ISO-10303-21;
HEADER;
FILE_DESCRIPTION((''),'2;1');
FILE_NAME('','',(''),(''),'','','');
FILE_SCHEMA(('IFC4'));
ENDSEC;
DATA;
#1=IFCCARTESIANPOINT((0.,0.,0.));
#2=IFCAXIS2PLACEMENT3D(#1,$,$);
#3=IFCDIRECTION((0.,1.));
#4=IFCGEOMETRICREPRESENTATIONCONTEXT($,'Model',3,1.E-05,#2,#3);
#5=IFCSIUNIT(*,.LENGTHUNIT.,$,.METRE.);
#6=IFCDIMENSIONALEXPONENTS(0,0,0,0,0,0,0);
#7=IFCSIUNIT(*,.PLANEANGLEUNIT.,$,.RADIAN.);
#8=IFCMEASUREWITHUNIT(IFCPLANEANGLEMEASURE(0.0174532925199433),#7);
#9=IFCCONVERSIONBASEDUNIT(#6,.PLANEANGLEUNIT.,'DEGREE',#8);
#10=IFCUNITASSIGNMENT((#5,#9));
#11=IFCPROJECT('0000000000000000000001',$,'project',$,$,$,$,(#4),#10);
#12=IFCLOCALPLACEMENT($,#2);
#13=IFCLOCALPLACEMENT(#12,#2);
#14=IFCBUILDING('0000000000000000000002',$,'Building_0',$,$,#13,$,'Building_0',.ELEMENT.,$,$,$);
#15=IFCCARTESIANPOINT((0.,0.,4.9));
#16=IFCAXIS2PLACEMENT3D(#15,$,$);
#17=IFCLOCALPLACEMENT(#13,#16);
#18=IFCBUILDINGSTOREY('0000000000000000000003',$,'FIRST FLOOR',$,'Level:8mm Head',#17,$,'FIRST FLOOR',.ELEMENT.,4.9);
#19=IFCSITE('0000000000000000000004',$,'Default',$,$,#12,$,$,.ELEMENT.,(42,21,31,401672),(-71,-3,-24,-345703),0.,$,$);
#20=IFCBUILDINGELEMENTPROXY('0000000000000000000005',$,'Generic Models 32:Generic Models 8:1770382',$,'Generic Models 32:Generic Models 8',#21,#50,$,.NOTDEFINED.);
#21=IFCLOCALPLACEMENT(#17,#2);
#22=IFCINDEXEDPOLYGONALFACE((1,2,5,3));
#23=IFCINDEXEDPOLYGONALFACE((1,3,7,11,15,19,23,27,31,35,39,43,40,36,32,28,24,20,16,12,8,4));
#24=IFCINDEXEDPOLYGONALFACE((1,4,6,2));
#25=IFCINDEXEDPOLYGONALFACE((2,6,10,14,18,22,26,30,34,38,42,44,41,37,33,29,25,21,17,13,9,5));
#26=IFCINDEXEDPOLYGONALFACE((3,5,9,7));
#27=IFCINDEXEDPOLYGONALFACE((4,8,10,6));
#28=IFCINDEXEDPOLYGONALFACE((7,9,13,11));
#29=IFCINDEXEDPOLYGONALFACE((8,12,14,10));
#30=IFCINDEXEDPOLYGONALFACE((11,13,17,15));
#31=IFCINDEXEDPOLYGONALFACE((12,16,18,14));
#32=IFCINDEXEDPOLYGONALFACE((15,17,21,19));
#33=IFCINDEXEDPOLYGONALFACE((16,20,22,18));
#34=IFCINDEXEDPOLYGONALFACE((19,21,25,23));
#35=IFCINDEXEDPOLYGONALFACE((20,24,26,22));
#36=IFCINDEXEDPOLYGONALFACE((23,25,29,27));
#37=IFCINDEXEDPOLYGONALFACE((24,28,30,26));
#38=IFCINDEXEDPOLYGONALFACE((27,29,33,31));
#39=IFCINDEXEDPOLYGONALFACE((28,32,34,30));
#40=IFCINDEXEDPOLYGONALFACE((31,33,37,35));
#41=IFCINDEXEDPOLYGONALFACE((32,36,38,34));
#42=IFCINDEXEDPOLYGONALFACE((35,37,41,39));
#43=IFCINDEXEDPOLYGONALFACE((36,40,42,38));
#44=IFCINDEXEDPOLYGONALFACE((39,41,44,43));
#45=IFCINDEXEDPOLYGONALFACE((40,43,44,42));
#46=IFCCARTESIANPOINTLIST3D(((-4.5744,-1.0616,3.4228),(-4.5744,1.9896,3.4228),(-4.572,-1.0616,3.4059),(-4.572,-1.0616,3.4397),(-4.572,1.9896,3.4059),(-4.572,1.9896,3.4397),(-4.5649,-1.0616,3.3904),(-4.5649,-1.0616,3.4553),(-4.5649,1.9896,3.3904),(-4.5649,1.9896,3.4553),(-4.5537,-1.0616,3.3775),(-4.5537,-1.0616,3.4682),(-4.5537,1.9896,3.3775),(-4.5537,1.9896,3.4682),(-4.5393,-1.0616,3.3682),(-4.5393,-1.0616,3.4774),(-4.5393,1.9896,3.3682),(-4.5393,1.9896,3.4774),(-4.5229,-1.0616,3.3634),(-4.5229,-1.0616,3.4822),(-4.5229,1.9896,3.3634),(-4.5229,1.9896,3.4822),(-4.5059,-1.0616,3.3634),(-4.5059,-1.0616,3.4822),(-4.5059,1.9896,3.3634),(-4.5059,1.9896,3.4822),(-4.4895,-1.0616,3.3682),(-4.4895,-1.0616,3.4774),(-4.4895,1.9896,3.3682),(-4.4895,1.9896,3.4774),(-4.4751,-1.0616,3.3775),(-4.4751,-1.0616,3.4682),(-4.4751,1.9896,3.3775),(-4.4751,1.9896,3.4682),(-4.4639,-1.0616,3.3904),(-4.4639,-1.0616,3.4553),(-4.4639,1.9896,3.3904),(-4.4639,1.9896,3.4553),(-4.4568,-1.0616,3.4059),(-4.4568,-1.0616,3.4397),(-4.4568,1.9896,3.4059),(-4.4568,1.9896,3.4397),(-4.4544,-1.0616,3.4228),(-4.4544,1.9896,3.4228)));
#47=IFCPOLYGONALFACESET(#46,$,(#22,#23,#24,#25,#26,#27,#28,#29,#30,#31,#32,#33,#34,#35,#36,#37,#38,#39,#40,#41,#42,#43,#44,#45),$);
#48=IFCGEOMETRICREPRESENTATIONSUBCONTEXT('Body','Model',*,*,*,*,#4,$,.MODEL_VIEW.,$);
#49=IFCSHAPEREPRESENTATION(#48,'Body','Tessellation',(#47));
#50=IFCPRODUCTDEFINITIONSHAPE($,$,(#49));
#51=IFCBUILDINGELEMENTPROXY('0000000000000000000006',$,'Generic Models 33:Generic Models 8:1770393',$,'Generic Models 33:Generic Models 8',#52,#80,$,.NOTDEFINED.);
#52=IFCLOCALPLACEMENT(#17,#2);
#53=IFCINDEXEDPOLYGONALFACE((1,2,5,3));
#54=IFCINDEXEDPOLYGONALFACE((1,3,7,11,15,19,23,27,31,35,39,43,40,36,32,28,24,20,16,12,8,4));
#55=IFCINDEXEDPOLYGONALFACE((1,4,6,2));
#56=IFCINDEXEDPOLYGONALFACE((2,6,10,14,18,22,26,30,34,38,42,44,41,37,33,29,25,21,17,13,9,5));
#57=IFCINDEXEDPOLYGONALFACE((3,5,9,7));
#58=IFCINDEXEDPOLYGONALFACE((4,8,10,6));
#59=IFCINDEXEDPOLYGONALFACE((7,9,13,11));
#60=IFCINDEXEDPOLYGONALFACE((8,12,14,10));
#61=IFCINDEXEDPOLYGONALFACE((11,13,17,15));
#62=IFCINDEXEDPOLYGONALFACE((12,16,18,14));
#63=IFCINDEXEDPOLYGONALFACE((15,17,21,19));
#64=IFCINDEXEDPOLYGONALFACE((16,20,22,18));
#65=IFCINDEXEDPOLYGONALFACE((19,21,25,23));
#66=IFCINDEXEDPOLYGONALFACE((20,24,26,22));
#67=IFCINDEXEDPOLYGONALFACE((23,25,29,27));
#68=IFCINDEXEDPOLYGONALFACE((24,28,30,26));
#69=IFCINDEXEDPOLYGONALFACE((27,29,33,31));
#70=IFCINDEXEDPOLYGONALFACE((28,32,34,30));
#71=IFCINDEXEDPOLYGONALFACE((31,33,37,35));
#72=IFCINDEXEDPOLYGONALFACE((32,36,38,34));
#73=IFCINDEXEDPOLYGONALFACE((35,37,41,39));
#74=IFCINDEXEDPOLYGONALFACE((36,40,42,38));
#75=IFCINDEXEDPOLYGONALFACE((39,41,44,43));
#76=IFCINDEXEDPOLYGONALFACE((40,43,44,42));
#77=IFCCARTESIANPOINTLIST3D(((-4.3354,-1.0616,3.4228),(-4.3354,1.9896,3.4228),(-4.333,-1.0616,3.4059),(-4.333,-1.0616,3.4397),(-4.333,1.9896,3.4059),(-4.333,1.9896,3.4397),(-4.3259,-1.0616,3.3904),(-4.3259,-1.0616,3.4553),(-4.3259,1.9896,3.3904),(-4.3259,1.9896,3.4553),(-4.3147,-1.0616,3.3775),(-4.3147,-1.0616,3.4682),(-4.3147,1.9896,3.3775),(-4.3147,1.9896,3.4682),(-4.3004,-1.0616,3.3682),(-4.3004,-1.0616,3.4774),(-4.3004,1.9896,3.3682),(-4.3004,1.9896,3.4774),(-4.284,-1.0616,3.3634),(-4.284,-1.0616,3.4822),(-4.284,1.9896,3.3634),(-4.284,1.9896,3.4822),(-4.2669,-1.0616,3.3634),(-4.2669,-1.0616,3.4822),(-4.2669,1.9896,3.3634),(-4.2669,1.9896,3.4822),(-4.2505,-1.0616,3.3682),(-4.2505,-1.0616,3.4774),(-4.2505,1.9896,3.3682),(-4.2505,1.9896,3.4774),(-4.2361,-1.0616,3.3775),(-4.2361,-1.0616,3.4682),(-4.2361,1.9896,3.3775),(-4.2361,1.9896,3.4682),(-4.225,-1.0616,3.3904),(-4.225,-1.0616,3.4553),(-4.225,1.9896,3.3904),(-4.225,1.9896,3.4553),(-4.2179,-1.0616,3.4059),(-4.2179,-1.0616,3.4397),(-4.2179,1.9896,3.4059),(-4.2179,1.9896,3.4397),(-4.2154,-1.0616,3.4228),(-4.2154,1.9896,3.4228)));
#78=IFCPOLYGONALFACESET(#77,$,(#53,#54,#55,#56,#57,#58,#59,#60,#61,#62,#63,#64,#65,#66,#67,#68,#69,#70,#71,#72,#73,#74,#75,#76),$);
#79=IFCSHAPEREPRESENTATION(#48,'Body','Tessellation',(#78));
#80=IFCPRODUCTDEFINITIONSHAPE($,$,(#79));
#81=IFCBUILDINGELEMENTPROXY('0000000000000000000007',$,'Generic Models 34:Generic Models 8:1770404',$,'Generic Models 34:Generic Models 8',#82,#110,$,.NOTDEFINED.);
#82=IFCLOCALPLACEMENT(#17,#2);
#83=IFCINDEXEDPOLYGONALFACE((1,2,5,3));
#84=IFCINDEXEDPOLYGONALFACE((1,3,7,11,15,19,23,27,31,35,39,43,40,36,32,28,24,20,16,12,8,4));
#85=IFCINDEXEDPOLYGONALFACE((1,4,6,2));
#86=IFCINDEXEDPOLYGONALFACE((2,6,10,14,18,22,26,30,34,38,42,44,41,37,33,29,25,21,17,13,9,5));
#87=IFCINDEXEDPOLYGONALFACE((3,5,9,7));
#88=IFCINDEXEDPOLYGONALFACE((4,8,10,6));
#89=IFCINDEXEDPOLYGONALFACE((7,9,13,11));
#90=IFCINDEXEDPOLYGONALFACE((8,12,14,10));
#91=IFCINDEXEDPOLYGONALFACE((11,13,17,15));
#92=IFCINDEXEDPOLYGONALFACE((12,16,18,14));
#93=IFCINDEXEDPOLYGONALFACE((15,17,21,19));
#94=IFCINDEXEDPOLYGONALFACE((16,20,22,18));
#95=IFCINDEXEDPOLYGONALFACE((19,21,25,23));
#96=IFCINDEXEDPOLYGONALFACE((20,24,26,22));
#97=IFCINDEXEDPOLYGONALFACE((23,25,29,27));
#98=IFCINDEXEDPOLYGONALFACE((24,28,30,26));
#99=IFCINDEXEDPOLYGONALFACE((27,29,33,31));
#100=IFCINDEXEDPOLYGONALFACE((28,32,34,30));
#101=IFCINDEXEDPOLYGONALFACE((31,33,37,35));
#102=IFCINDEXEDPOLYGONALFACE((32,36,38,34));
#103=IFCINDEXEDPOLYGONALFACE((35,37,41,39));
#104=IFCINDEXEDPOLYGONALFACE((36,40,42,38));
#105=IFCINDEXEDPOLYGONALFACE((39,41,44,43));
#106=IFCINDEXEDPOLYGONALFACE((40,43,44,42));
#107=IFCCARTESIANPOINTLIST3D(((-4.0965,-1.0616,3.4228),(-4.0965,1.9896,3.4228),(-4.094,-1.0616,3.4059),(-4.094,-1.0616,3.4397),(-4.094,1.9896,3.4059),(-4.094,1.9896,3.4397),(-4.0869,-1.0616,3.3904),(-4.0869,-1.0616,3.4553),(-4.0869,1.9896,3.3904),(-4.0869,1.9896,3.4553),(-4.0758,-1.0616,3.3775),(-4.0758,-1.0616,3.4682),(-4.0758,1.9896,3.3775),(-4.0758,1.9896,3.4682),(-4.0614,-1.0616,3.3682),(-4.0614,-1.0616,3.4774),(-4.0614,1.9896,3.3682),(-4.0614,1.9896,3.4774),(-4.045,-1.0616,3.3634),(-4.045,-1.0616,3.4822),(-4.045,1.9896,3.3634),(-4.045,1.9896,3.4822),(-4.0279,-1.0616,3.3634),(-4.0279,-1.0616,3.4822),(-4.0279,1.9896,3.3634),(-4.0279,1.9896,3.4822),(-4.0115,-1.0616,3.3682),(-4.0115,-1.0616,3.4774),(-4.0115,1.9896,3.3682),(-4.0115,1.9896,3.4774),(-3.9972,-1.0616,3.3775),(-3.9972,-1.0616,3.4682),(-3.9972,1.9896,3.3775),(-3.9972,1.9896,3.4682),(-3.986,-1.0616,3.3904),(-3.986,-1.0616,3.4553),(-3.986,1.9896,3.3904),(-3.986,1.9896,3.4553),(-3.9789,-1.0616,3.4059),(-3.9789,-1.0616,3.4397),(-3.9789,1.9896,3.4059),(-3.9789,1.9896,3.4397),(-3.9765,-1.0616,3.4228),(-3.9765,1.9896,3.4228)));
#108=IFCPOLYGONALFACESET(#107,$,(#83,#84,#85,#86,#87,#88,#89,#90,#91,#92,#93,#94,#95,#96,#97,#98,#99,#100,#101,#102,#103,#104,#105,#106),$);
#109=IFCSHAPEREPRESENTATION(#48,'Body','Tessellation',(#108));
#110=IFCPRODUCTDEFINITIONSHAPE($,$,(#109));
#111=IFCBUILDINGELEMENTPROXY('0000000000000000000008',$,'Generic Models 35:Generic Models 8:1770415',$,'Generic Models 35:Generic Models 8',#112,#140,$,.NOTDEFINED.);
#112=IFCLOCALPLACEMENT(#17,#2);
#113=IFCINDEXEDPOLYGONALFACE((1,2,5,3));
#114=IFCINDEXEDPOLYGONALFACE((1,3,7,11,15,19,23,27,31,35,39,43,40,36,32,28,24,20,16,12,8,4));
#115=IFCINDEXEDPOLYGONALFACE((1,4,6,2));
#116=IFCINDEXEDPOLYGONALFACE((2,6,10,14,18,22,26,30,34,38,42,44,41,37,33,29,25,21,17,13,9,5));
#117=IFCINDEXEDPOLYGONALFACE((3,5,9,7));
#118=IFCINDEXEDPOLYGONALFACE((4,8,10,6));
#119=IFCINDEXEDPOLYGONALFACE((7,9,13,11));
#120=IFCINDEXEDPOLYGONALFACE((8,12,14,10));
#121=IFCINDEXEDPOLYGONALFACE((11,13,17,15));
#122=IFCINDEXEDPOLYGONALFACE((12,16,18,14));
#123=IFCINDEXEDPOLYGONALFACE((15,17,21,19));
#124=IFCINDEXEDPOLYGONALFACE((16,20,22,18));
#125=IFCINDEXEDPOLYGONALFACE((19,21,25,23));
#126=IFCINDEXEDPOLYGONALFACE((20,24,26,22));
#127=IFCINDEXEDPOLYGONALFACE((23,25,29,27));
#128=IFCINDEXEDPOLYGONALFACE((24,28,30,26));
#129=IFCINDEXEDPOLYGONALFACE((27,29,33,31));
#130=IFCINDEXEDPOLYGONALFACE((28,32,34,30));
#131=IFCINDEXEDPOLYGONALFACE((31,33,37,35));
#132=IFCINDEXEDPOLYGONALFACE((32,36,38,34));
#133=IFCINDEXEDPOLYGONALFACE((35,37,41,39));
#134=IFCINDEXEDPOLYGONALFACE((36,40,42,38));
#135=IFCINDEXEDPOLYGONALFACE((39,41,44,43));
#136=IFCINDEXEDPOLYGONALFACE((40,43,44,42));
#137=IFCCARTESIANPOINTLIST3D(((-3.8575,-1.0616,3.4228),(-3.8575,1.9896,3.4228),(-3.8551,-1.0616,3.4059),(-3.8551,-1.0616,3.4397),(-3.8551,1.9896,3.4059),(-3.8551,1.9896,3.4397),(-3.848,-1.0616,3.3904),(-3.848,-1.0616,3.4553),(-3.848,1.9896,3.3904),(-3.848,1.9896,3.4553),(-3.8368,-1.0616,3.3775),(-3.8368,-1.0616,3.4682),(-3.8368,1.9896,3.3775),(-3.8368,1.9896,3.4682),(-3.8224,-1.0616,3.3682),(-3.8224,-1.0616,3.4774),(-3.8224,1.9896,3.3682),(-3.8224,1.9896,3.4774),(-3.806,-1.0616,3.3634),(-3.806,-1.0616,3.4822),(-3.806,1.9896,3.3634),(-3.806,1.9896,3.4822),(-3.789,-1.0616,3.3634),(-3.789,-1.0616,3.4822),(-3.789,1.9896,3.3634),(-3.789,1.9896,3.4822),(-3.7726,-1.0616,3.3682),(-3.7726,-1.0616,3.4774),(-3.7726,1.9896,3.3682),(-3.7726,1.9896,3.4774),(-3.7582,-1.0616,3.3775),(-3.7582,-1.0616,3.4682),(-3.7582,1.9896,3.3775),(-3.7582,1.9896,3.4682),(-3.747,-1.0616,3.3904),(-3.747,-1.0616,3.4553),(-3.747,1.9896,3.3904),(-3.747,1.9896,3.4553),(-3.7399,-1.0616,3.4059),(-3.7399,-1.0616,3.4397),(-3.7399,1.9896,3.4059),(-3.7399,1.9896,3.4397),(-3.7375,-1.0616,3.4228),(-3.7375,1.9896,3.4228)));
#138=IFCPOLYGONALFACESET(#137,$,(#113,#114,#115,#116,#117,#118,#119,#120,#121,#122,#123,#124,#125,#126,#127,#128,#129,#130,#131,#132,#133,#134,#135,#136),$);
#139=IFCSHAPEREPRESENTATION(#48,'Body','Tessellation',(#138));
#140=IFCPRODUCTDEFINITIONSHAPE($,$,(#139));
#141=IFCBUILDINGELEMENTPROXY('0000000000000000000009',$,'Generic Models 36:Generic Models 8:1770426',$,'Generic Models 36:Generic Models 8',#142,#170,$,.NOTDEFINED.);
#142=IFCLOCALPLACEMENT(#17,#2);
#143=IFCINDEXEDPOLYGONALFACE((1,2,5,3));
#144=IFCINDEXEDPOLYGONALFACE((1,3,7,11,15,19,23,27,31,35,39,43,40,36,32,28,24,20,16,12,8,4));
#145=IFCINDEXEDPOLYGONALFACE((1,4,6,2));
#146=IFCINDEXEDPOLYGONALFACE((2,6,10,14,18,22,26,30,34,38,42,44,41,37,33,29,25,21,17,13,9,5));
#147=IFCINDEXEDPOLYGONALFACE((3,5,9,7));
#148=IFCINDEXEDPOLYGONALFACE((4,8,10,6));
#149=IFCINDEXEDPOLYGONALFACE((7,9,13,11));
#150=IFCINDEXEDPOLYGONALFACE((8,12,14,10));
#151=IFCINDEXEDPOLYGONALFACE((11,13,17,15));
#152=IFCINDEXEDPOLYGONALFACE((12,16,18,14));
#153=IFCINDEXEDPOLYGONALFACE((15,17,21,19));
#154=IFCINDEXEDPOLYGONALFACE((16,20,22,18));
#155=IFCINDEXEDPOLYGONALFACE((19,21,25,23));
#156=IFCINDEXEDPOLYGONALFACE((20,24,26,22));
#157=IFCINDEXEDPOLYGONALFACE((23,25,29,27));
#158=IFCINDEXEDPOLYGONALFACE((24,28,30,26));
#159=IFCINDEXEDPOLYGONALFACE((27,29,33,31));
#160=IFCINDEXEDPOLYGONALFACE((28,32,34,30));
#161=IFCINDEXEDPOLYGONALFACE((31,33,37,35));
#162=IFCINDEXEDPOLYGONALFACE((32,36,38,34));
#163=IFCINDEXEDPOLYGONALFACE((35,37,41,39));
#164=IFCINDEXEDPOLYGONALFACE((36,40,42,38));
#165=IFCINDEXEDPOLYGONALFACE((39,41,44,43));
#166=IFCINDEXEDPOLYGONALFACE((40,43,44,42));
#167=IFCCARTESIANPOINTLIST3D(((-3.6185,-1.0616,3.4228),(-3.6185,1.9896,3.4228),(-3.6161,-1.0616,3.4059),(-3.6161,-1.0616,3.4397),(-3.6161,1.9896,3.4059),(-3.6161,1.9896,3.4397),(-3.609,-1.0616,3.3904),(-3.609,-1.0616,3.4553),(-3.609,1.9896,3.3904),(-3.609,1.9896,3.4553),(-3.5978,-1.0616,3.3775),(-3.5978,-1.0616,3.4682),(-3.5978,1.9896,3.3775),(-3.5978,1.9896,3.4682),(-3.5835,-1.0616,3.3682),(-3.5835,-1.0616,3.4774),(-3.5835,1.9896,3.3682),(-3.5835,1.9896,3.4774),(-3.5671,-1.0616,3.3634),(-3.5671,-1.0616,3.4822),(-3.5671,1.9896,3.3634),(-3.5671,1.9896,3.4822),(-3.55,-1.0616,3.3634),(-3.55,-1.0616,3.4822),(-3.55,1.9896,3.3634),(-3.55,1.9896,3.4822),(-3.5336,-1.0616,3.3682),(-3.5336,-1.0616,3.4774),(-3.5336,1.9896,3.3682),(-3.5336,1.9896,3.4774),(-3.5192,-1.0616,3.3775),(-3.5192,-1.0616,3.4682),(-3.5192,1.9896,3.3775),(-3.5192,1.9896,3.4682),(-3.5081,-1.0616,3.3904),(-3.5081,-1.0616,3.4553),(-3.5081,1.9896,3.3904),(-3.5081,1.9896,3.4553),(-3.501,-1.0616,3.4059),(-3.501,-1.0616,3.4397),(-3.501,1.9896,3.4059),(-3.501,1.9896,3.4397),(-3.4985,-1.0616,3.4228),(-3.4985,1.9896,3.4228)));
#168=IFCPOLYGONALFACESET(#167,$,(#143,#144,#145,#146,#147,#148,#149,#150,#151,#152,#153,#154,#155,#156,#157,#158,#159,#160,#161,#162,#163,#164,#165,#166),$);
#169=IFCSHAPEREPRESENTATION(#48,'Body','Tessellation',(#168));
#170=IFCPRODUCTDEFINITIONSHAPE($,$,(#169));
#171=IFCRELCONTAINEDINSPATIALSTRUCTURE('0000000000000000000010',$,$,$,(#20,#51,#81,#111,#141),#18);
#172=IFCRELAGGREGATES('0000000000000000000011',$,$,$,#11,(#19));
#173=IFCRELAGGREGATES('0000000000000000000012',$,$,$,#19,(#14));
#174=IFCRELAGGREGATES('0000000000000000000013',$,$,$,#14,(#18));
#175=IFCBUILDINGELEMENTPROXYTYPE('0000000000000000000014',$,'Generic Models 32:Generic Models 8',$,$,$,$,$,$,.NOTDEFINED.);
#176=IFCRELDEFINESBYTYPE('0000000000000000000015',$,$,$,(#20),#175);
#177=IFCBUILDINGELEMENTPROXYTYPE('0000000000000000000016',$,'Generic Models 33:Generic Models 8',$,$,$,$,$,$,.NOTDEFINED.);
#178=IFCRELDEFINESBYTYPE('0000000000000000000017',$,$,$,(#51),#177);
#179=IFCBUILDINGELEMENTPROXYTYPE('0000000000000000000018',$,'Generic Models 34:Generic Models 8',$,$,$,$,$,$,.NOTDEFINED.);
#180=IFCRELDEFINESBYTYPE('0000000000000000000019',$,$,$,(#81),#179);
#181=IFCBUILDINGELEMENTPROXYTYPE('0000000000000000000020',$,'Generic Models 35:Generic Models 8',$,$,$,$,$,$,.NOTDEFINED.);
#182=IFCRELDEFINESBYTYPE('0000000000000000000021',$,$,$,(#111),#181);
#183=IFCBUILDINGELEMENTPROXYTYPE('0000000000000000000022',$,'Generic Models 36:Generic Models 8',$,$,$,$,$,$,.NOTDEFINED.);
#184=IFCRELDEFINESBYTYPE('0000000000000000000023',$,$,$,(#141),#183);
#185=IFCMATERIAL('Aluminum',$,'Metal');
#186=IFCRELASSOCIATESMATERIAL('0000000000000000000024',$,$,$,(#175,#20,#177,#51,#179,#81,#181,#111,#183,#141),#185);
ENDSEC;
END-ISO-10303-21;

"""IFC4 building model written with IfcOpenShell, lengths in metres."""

from ifc_helpers import new_model, entity, si_unit, converted_unit, direction, frame, origin, place, context, subcontext, project, spatial, arc, indexed_curve, outline, extrude, source, transform, mapped, material, type_object, type_shapes, element, save


model = new_model("IFC4")

# Units and contexts
model_context = context("Model", 3, precision=1e-05, world=origin(), true_north=direction((0.0, 1.0)))
body_context = subcontext(model_context, "Body", "Model", "MODEL_VIEW")
ifc_project = project(units=[si_unit("LENGTHUNIT", "METRE"), converted_unit("PLANEANGLEUNIT", "DEGREE", entity("IfcPlaneAngleMeasure", 0.0174532925199433), si_unit("PLANEANGLEUNIT", "RADIAN"), dimensions=[0, 0, 0, 0, 0, 0, 0])], contexts=[model_context])

# Site, building, storey
site_placement = place(None, origin())
site = spatial("IfcSite", under=ifc_project, at=site_placement, Name="Default", CompositionType="ELEMENT", RefLatitude=(42, 21, 31, 401672), RefLongitude=(-71, -3, -24, -345703), RefElevation=0.0)
building_placement = place(site_placement, origin())
building = spatial("IfcBuilding", under=site, at=building_placement, Name="Building_0", LongName="Building_0", CompositionType="ELEMENT")
storey_placement = place(building_placement, frame((0.0, 0.0, 4.9)))
storey = spatial("IfcBuildingStorey", under=building, at=storey_placement, Name="FIRST FLOOR", ObjectType="Level:8mm Head", LongName="FIRST FLOOR", CompositionType="ELEMENT", Elevation=4.9)

# Building element proxies
ifc_material = material(Name="Aluminum", Category="Metal")
building_element_proxy_type_1 = type_object("IfcBuildingElementProxyType", Name="Generic Models 32:Generic Models 8", PredefinedType="NOTDEFINED", material=ifc_material)
shared_shape_1 = source(origin(), body_context, "Body", "SweptSolid", [
    extrude(outline(indexed_curve([(-0.06, 0.0), (0.0, -0.06), (0.06, 0.0), (0.0, 0.06)], segments=[arc(1, 2, 3), arc(3, 4, 1)], self_intersect=False)), frame((-4.5144, -1.0616, 8.3228), z_axis=(0.0, 1.0, 0.0), x_axis=(-1.0, 0.0, 0.0)), (0.0, 0.0, 1.0), 3.0512),
])
type_shapes(building_element_proxy_type_1, [shared_shape_1])
proxy_1_placement = place(storey_placement, frame((0.0, 0.0, -4.9)))
element("IfcBuildingElementProxy", 1, at=proxy_1_placement, inside=storey, type_object=building_element_proxy_type_1, material=ifc_material, Name="Generic Models 32:Generic Models 8:1770382", ObjectType="Generic Models 32:Generic Models 8", PredefinedType="NOTDEFINED", context=body_context, shape_type="MappedRepresentation", body=[
    mapped(shared_shape_1, transform((0.0, 0.0, 0.0), scale=1.0)),
])
building_element_proxy_type_2 = type_object("IfcBuildingElementProxyType", Name="Generic Models 33:Generic Models 8", PredefinedType="NOTDEFINED", material=ifc_material)
shared_shape_2 = source(origin(), body_context, "Body", "SweptSolid", [
    extrude(outline(indexed_curve([(-0.06, 0.0), (0.0, -0.06), (0.06, 0.0), (0.0, 0.06)], segments=[arc(1, 2, 3), arc(3, 4, 1)], self_intersect=False)), frame((-4.2754, -1.0616, 8.3228), z_axis=(0.0, 1.0, 0.0), x_axis=(-1.0, 0.0, 0.0)), (0.0, 0.0, 1.0), 3.0512),
])
type_shapes(building_element_proxy_type_2, [shared_shape_2])
proxy_2_placement = place(storey_placement, frame((0.0, 0.0, -4.9)))
element("IfcBuildingElementProxy", 2, at=proxy_2_placement, inside=storey, type_object=building_element_proxy_type_2, material=ifc_material, Name="Generic Models 33:Generic Models 8:1770393", ObjectType="Generic Models 33:Generic Models 8", PredefinedType="NOTDEFINED", context=body_context, shape_type="MappedRepresentation", body=[
    mapped(shared_shape_2, transform((0.0, 0.0, 0.0), scale=1.0)),
])
building_element_proxy_type_3 = type_object("IfcBuildingElementProxyType", Name="Generic Models 34:Generic Models 8", PredefinedType="NOTDEFINED", material=ifc_material)
shared_shape_3 = source(origin(), body_context, "Body", "SweptSolid", [
    extrude(outline(indexed_curve([(-0.06, 0.0), (0.0, -0.06), (0.06, 0.0), (0.0, 0.06)], segments=[arc(1, 2, 3), arc(3, 4, 1)], self_intersect=False)), frame((-4.0365, -1.0616, 8.3228), z_axis=(0.0, 1.0, 0.0), x_axis=(-1.0, 0.0, 0.0)), (0.0, 0.0, 1.0), 3.0512),
])
type_shapes(building_element_proxy_type_3, [shared_shape_3])
proxy_3_placement = place(storey_placement, frame((0.0, 0.0, -4.9)))
element("IfcBuildingElementProxy", 3, at=proxy_3_placement, inside=storey, type_object=building_element_proxy_type_3, material=ifc_material, Name="Generic Models 34:Generic Models 8:1770404", ObjectType="Generic Models 34:Generic Models 8", PredefinedType="NOTDEFINED", context=body_context, shape_type="MappedRepresentation", body=[
    mapped(shared_shape_3, transform((0.0, 0.0, 0.0), scale=1.0)),
])
building_element_proxy_type_4 = type_object("IfcBuildingElementProxyType", Name="Generic Models 35:Generic Models 8", PredefinedType="NOTDEFINED", material=ifc_material)
shared_shape_4 = source(origin(), body_context, "Body", "SweptSolid", [
    extrude(outline(indexed_curve([(-0.06, 0.0), (0.0, -0.06), (0.06, 0.0), (0.0, 0.06)], segments=[arc(1, 2, 3), arc(3, 4, 1)], self_intersect=False)), frame((-3.7975, -1.0616, 8.3228), z_axis=(0.0, 1.0, 0.0), x_axis=(-1.0, 0.0, 0.0)), (0.0, 0.0, 1.0), 3.0512),
])
type_shapes(building_element_proxy_type_4, [shared_shape_4])
proxy_4_placement = place(storey_placement, frame((0.0, 0.0, -4.9)))
element("IfcBuildingElementProxy", 4, at=proxy_4_placement, inside=storey, type_object=building_element_proxy_type_4, material=ifc_material, Name="Generic Models 35:Generic Models 8:1770415", ObjectType="Generic Models 35:Generic Models 8", PredefinedType="NOTDEFINED", context=body_context, shape_type="MappedRepresentation", body=[
    mapped(shared_shape_4, transform((0.0, 0.0, 0.0), scale=1.0)),
])
building_element_proxy_type_5 = type_object("IfcBuildingElementProxyType", Name="Generic Models 36:Generic Models 8", PredefinedType="NOTDEFINED", material=ifc_material)
shared_shape_5 = source(origin(), body_context, "Body", "SweptSolid", [
    extrude(outline(indexed_curve([(-0.06, 0.0), (0.0, -0.06), (0.06, 0.0), (0.0, 0.06)], segments=[arc(1, 2, 3), arc(3, 4, 1)], self_intersect=False)), frame((-3.5585, -1.0616, 8.3228), z_axis=(0.0, 1.0, 0.0), x_axis=(-1.0, 0.0, 0.0)), (0.0, 0.0, 1.0), 3.0512),
])
type_shapes(building_element_proxy_type_5, [shared_shape_5])
proxy_5_placement = place(storey_placement, frame((0.0, 0.0, -4.9)))
element("IfcBuildingElementProxy", 5, at=proxy_5_placement, inside=storey, type_object=building_element_proxy_type_5, material=ifc_material, Name="Generic Models 36:Generic Models 8:1770426", ObjectType="Generic Models 36:Generic Models 8", PredefinedType="NOTDEFINED", context=body_context, shape_type="MappedRepresentation", body=[
    mapped(shared_shape_5, transform((0.0, 0.0, 0.0), scale=1.0)),
])

save(model, "model.ifc")
